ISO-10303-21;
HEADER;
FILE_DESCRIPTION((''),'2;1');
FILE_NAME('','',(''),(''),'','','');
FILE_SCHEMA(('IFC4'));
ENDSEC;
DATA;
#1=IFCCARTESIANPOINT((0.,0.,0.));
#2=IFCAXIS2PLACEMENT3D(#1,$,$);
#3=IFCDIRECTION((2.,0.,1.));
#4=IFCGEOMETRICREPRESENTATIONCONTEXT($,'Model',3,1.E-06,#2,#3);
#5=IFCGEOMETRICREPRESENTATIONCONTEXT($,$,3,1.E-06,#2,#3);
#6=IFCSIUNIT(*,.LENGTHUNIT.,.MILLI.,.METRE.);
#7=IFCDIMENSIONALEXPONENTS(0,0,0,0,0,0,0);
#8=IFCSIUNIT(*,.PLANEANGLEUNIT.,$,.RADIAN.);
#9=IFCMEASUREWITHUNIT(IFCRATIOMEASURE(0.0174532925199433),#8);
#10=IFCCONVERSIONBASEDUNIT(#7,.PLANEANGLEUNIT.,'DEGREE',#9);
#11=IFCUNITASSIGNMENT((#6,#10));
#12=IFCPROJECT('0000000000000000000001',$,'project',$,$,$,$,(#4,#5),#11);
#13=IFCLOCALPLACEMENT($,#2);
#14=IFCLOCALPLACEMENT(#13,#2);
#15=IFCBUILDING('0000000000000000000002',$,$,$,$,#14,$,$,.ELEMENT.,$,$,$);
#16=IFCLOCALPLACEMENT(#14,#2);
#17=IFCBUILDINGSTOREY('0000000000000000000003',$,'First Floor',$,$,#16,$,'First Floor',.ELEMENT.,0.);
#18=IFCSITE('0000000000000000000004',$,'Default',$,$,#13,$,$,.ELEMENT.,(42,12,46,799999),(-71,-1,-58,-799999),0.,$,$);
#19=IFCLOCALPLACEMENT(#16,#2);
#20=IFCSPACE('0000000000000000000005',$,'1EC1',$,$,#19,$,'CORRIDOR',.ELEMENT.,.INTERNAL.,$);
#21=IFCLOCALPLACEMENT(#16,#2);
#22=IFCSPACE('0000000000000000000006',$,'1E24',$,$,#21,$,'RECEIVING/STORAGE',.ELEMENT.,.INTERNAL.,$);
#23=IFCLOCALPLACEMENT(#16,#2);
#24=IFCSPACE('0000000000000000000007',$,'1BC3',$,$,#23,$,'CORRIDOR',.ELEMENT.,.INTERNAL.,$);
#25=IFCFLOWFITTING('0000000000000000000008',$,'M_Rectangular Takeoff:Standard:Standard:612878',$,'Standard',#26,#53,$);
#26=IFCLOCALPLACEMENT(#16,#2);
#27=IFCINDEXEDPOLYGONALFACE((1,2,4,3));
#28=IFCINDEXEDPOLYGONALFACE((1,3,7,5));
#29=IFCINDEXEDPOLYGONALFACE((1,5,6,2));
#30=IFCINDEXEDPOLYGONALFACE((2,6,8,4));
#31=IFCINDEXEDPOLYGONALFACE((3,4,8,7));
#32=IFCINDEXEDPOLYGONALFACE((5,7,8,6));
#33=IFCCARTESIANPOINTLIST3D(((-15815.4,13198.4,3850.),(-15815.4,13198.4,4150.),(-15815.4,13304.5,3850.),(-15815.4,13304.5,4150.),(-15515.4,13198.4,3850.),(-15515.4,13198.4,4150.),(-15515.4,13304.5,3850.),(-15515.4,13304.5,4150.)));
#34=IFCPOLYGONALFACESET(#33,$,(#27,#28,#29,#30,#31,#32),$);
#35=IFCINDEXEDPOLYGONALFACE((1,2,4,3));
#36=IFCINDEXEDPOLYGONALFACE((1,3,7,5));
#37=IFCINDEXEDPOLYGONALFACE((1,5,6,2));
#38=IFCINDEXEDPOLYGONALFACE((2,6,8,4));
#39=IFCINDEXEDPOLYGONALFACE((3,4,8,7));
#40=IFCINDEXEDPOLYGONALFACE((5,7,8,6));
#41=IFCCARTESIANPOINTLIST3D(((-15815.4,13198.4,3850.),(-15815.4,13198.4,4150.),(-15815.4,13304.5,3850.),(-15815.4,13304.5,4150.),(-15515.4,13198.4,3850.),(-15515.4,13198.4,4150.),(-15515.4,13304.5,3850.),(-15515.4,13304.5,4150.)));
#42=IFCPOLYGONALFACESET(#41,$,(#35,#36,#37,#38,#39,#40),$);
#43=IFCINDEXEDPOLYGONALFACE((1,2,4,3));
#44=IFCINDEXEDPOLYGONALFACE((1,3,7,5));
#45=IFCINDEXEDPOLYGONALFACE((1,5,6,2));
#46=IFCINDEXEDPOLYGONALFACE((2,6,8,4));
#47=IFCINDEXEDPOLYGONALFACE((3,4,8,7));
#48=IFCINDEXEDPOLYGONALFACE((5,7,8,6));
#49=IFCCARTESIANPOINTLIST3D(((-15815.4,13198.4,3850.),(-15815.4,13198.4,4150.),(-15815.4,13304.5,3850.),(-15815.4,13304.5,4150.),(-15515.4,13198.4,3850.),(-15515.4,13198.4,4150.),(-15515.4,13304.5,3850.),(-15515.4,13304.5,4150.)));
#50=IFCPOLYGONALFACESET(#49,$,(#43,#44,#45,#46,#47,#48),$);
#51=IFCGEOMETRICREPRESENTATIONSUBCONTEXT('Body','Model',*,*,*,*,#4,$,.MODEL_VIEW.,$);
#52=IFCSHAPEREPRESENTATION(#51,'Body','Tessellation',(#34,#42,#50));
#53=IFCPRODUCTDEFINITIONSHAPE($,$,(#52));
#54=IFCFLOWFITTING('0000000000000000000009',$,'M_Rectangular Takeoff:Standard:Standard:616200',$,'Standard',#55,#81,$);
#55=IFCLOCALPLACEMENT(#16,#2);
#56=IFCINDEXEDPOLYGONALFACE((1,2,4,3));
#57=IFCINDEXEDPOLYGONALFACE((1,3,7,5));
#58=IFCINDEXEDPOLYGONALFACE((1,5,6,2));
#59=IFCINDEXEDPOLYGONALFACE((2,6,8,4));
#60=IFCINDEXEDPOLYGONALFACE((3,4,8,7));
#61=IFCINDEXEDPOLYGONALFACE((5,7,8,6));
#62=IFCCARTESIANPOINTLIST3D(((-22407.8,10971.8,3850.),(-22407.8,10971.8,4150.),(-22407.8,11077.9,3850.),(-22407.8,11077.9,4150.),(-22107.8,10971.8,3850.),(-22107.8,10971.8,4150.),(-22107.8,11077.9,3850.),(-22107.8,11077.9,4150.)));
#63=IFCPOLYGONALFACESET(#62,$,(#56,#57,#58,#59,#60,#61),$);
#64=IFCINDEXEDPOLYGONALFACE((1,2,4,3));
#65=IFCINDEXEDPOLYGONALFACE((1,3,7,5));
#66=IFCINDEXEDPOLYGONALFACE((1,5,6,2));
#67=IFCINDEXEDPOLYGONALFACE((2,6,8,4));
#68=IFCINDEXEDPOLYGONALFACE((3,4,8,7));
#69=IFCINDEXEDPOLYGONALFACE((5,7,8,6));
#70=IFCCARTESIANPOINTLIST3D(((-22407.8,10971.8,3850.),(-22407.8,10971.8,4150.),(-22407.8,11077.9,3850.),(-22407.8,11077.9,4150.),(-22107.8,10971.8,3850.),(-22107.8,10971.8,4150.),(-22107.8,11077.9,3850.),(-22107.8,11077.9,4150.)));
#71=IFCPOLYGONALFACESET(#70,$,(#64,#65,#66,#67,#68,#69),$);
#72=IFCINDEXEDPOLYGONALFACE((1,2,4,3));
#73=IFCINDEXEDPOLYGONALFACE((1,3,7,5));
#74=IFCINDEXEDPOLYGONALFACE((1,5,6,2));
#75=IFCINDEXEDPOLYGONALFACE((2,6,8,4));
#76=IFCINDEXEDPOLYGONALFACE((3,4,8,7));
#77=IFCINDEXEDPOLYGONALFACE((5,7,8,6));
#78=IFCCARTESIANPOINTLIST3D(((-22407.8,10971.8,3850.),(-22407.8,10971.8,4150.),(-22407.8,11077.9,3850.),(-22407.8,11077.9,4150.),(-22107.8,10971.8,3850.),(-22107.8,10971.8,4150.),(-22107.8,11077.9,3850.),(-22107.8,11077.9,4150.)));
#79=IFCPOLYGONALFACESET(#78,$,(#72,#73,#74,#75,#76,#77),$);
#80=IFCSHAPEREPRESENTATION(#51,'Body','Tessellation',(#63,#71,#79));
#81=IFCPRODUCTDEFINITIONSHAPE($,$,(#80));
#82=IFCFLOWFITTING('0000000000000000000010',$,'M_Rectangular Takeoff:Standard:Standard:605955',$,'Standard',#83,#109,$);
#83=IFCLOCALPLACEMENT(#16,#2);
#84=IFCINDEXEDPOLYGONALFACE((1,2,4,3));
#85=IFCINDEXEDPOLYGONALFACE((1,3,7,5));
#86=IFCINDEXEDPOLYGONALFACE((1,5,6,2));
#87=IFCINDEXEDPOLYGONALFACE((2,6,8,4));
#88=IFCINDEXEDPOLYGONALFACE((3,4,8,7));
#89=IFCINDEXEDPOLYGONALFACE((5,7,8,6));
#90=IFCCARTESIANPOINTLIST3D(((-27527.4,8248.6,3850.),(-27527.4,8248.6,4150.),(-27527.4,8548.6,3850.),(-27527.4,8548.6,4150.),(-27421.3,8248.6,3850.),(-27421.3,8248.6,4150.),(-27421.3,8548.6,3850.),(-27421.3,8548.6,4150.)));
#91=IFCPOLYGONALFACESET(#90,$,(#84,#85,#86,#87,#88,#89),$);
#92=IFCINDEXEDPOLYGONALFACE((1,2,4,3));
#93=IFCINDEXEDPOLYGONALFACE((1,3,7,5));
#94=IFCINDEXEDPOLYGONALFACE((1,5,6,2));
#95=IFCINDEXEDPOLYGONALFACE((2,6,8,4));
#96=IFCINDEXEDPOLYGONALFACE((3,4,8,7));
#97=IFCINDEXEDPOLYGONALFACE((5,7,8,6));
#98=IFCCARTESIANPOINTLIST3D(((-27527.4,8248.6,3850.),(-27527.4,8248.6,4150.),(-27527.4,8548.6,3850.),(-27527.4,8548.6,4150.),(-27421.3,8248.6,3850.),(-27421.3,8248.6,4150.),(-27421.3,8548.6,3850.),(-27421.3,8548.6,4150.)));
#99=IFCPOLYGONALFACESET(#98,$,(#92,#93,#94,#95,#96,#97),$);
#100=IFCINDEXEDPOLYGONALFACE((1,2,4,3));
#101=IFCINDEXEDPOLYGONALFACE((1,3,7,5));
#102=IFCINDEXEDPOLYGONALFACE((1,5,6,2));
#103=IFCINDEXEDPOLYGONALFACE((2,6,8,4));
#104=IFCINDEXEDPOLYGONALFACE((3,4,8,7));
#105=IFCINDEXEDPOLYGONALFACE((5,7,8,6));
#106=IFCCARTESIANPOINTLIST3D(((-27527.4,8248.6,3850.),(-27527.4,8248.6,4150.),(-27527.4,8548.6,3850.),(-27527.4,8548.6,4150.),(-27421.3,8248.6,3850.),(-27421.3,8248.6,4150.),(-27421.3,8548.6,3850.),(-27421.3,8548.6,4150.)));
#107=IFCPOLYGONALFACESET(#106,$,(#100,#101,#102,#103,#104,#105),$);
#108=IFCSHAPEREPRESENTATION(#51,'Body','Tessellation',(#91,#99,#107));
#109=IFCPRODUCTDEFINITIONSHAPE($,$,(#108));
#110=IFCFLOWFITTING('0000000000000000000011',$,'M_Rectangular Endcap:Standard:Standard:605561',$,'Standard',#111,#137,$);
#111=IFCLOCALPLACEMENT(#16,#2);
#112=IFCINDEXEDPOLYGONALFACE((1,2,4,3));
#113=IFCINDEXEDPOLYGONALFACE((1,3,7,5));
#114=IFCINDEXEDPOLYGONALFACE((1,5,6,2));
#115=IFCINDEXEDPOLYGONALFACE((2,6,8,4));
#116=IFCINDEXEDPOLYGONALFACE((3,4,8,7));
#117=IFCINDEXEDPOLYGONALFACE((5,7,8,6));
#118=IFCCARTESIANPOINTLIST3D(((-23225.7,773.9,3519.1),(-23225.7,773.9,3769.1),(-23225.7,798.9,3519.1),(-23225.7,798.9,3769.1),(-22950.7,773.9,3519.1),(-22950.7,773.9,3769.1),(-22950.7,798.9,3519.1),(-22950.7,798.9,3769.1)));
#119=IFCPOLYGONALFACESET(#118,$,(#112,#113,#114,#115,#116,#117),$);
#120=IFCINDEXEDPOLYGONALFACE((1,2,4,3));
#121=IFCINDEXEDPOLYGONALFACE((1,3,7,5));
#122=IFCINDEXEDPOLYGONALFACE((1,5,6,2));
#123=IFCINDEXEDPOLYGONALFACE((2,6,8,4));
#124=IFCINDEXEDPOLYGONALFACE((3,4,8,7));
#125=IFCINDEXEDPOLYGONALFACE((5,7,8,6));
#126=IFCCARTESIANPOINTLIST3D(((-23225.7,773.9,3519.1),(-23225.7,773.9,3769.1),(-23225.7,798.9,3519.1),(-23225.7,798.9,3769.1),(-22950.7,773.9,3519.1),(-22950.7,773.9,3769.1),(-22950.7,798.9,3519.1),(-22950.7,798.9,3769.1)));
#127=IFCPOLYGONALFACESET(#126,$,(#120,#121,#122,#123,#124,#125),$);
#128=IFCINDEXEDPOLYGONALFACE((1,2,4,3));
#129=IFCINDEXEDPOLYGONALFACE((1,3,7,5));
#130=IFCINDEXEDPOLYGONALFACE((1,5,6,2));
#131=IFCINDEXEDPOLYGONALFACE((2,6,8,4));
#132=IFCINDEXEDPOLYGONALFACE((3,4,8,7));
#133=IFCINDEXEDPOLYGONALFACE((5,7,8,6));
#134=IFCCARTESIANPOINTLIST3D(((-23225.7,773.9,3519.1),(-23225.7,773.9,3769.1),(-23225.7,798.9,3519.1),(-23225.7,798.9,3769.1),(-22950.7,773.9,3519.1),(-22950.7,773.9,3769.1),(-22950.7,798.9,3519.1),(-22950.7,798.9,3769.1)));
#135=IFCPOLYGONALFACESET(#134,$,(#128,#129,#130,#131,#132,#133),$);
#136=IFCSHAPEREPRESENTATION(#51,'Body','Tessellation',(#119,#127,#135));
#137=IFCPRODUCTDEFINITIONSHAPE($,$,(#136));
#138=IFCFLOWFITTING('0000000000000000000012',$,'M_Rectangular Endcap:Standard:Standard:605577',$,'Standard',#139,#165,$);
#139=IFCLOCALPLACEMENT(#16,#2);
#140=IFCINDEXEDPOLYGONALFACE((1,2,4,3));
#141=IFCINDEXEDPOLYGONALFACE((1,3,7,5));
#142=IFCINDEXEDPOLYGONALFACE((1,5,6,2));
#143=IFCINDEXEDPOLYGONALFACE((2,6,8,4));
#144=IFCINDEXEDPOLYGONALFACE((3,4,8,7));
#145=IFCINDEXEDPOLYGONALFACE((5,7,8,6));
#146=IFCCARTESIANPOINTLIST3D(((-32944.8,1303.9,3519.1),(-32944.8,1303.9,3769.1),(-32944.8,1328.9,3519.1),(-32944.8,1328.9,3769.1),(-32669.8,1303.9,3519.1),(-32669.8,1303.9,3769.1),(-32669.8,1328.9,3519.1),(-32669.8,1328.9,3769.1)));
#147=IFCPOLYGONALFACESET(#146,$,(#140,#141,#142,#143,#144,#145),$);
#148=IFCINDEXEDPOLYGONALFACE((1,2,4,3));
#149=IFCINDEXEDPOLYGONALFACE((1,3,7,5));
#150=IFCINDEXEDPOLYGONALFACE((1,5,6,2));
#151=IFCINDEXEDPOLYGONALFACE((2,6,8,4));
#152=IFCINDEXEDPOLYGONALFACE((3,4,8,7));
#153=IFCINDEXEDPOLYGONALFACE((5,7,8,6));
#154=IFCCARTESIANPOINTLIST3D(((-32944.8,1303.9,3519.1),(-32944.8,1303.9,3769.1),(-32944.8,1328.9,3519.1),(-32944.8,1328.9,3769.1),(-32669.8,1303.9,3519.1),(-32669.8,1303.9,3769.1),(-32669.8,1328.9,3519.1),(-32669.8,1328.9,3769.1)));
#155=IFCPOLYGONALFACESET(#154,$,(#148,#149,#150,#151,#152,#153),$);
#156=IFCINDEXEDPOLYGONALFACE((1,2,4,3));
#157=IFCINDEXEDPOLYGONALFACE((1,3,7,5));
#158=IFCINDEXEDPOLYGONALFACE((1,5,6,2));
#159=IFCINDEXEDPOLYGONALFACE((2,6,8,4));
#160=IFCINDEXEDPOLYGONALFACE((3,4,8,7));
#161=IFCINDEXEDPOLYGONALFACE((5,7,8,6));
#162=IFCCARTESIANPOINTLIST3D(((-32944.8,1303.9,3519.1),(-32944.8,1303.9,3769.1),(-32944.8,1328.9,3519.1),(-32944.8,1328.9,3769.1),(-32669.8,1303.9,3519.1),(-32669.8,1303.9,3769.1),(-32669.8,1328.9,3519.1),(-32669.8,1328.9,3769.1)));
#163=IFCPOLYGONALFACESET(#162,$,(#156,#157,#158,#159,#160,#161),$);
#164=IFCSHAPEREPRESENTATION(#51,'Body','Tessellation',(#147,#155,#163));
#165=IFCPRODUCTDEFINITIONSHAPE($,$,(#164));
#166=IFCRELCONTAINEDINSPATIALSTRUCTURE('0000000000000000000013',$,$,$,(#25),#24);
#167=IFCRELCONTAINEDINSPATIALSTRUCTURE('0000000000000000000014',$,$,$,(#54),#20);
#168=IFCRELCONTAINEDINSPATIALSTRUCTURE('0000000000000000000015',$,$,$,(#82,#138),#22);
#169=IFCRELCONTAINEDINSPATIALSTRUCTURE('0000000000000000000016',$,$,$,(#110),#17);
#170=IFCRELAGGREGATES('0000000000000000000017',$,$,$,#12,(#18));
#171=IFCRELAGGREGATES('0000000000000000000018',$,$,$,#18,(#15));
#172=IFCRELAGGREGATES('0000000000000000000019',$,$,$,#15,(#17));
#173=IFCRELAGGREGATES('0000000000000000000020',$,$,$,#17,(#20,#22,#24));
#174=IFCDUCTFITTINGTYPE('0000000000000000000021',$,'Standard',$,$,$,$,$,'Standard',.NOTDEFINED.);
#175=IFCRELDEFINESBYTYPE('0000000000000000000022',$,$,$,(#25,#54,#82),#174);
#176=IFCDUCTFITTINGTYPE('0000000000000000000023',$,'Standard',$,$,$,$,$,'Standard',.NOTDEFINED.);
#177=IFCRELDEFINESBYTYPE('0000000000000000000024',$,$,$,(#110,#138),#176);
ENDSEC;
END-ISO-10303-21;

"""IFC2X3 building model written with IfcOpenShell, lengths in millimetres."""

from ifc_helpers import new_model, entity, si_unit, converted_unit, direction, frame, frame_2d, origin, origin_2d_with_axis, place, context, subcontext, project, spatial, rectangle, extrude, source, transform, mapped, type_object, type_shapes, element, save


model = new_model("IFC2X3")

# Units and contexts
model_context = context("Model", 3, precision=1e-06, world=origin(), true_north=direction((2.0, 0.0, 1.0)))
context_of_model = context(None, 3, precision=1e-06, world=origin(), true_north=direction((2.0, 0.0, 1.0)))
body_context = subcontext(model_context, "Body", "Model", "MODEL_VIEW")
ifc_project = project(units=[si_unit("LENGTHUNIT", "METRE", prefix="MILLI"), converted_unit("PLANEANGLEUNIT", "DEGREE", entity("IfcRatioMeasure", 0.0174532925199433), si_unit("PLANEANGLEUNIT", "RADIAN"), dimensions=[0, 0, 0, 0, 0, 0, 0])], contexts=[model_context, context_of_model])

# Site, building, storey
site_placement = place(None, origin())
site = spatial("IfcSite", under=ifc_project, at=site_placement, Name="Default", CompositionType="ELEMENT", RefLatitude=(42, 12, 46, 799999), RefLongitude=(-71, -1, -58, -799999), RefElevation=0.0)
building_placement = place(site_placement, origin())
building = spatial("IfcBuilding", under=site, at=building_placement, CompositionType="ELEMENT")
storey_placement = place(building_placement, origin())
storey = spatial("IfcBuildingStorey", under=building, at=storey_placement, Name="First Floor", LongName="First Floor", CompositionType="ELEMENT", Elevation=0.0)

# Shared definitions
space_1_placement = place(storey_placement, origin())
space_1 = spatial("IfcSpace", under=storey, at=space_1_placement, Name="1EC1", LongName="CORRIDOR", CompositionType="ELEMENT", InteriorOrExteriorSpace="INTERNAL")

# Shared definitions
space_2_placement = place(storey_placement, origin())
space_2 = spatial("IfcSpace", under=storey, at=space_2_placement, Name="1E24", LongName="RECEIVING/STORAGE", CompositionType="ELEMENT", InteriorOrExteriorSpace="INTERNAL")

# Shared definitions
duct_fitting_type_1 = type_object("IfcDuctFittingType", Name="Standard", ElementType="Standard", PredefinedType="NOTDEFINED")
shared_shape_1 = source(origin(), body_context, "Body", "SweptSolid", [
    extrude(rectangle(XDim=106.1, YDim=300.0, at=frame_2d((0.0, 0.0), x_axis=(1.0, 0.0))), frame((47.0, 0.0, -150.0)), (0.0, 0.0, 1.0), 300.0),
    extrude(rectangle(XDim=106.1, YDim=300.0, at=frame_2d((0.0, 0.0), x_axis=(1.0, 0.0))), frame((47.0, 0.0, -150.0)), (0.0, 0.0, 1.0), 300.0),
    extrude(rectangle(XDim=106.1, YDim=300.0, at=frame_2d((0.0, 0.0), x_axis=(1.0, 0.0))), frame((47.0, 0.0, -150.0)), (0.0, 0.0, 1.0), 300.0),
])
type_shapes(duct_fitting_type_1, [shared_shape_1])

# Shared definitions
space_3_placement = place(storey_placement, origin())
space_3 = spatial("IfcSpace", under=storey, at=space_3_placement, Name="1BC3", LongName="CORRIDOR", CompositionType="ELEMENT", InteriorOrExteriorSpace="INTERNAL")

# Flow fittings
flow_fitting_1_placement = place(space_3_placement, frame((-15665.4, 13204.5, 4000.0), z_axis=(0.0, 0.0, -1.0), x_axis=(0.0, 1.0, 0.0)))
element("IfcFlowFitting", 1, at=flow_fitting_1_placement, inside=space_3, type_object=duct_fitting_type_1, Name="M_Rectangular Takeoff:Standard:Standard:612878", ObjectType="Standard", context=body_context, shape_type="MappedRepresentation", body=[
    mapped(shared_shape_1, transform((0.0, 0.0, 0.0), scale=1.0)),
])
flow_fitting_2_placement = place(space_1_placement, frame((-22257.8, 10977.9, 4000.0), z_axis=(0.0, 0.0, -1.0), x_axis=(0.0, 1.0, 0.0)))
element("IfcFlowFitting", 2, at=flow_fitting_2_placement, inside=space_1, type_object=duct_fitting_type_1, Name="M_Rectangular Takeoff:Standard:Standard:616200", ObjectType="Standard", context=body_context, shape_type="MappedRepresentation", body=[
    mapped(shared_shape_1, transform((0.0, 0.0, 0.0), scale=1.0)),
])
flow_fitting_3_placement = place(space_2_placement, frame((-27521.3, 8398.6, 4000.0), z_axis=(0.0, 0.0, -1.0), x_axis=(1.0, 0.0, 0.0)))
element("IfcFlowFitting", 3, at=flow_fitting_3_placement, inside=space_2, type_object=duct_fitting_type_1, Name="M_Rectangular Takeoff:Standard:Standard:605955", ObjectType="Standard", context=body_context, shape_type="MappedRepresentation", body=[
    mapped(shared_shape_1, transform((0.0, 0.0, 0.0), scale=1.0)),
])

# Flow fittings
duct_fitting_type_2 = type_object("IfcDuctFittingType", Name="Standard", ElementType="Standard", PredefinedType="NOTDEFINED")
shared_shape_2 = source(origin(), body_context, "Body", "SweptSolid", [
    extrude(rectangle(XDim=25.0, YDim=275.0, at=origin_2d_with_axis()), frame((12.5, 0.0, -125.0)), (0.0, 0.0, 1.0), 250.0),
    extrude(rectangle(XDim=25.0, YDim=275.0, at=origin_2d_with_axis()), frame((12.5, 0.0, -125.0)), (0.0, 0.0, 1.0), 250.0),
    extrude(rectangle(XDim=25.0, YDim=275.0, at=frame_2d((0.0, 0.0), x_axis=(1.0, 0.0))), frame((12.5, 0.0, -125.0)), (0.0, 0.0, 1.0), 250.0),
])
type_shapes(duct_fitting_type_2, [shared_shape_2])
flow_fitting_4_placement = place(storey_placement, frame((-23088.2, 798.9, 3644.1), z_axis=(0.0, 0.0, 1.0), x_axis=(0.0, -1.0, 0.0)))
element("IfcFlowFitting", 4, at=flow_fitting_4_placement, inside=storey, type_object=duct_fitting_type_2, Name="M_Rectangular Endcap:Standard:Standard:605561", ObjectType="Standard", context=body_context, shape_type="MappedRepresentation", body=[
    mapped(shared_shape_2, transform((0.0, 0.0, 0.0), scale=1.0)),
])
flow_fitting_5_placement = place(space_2_placement, frame((-32807.3, 1328.9, 3644.1), z_axis=(0.0, 0.0, 1.0), x_axis=(0.0, -1.0, 0.0)))
element("IfcFlowFitting", 5, at=flow_fitting_5_placement, inside=space_2, type_object=duct_fitting_type_2, Name="M_Rectangular Endcap:Standard:Standard:605577", ObjectType="Standard", context=body_context, shape_type="MappedRepresentation", body=[
    mapped(shared_shape_2, transform((0.0, 0.0, 0.0), scale=1.0)),
])

save(model, "model.ifc")
